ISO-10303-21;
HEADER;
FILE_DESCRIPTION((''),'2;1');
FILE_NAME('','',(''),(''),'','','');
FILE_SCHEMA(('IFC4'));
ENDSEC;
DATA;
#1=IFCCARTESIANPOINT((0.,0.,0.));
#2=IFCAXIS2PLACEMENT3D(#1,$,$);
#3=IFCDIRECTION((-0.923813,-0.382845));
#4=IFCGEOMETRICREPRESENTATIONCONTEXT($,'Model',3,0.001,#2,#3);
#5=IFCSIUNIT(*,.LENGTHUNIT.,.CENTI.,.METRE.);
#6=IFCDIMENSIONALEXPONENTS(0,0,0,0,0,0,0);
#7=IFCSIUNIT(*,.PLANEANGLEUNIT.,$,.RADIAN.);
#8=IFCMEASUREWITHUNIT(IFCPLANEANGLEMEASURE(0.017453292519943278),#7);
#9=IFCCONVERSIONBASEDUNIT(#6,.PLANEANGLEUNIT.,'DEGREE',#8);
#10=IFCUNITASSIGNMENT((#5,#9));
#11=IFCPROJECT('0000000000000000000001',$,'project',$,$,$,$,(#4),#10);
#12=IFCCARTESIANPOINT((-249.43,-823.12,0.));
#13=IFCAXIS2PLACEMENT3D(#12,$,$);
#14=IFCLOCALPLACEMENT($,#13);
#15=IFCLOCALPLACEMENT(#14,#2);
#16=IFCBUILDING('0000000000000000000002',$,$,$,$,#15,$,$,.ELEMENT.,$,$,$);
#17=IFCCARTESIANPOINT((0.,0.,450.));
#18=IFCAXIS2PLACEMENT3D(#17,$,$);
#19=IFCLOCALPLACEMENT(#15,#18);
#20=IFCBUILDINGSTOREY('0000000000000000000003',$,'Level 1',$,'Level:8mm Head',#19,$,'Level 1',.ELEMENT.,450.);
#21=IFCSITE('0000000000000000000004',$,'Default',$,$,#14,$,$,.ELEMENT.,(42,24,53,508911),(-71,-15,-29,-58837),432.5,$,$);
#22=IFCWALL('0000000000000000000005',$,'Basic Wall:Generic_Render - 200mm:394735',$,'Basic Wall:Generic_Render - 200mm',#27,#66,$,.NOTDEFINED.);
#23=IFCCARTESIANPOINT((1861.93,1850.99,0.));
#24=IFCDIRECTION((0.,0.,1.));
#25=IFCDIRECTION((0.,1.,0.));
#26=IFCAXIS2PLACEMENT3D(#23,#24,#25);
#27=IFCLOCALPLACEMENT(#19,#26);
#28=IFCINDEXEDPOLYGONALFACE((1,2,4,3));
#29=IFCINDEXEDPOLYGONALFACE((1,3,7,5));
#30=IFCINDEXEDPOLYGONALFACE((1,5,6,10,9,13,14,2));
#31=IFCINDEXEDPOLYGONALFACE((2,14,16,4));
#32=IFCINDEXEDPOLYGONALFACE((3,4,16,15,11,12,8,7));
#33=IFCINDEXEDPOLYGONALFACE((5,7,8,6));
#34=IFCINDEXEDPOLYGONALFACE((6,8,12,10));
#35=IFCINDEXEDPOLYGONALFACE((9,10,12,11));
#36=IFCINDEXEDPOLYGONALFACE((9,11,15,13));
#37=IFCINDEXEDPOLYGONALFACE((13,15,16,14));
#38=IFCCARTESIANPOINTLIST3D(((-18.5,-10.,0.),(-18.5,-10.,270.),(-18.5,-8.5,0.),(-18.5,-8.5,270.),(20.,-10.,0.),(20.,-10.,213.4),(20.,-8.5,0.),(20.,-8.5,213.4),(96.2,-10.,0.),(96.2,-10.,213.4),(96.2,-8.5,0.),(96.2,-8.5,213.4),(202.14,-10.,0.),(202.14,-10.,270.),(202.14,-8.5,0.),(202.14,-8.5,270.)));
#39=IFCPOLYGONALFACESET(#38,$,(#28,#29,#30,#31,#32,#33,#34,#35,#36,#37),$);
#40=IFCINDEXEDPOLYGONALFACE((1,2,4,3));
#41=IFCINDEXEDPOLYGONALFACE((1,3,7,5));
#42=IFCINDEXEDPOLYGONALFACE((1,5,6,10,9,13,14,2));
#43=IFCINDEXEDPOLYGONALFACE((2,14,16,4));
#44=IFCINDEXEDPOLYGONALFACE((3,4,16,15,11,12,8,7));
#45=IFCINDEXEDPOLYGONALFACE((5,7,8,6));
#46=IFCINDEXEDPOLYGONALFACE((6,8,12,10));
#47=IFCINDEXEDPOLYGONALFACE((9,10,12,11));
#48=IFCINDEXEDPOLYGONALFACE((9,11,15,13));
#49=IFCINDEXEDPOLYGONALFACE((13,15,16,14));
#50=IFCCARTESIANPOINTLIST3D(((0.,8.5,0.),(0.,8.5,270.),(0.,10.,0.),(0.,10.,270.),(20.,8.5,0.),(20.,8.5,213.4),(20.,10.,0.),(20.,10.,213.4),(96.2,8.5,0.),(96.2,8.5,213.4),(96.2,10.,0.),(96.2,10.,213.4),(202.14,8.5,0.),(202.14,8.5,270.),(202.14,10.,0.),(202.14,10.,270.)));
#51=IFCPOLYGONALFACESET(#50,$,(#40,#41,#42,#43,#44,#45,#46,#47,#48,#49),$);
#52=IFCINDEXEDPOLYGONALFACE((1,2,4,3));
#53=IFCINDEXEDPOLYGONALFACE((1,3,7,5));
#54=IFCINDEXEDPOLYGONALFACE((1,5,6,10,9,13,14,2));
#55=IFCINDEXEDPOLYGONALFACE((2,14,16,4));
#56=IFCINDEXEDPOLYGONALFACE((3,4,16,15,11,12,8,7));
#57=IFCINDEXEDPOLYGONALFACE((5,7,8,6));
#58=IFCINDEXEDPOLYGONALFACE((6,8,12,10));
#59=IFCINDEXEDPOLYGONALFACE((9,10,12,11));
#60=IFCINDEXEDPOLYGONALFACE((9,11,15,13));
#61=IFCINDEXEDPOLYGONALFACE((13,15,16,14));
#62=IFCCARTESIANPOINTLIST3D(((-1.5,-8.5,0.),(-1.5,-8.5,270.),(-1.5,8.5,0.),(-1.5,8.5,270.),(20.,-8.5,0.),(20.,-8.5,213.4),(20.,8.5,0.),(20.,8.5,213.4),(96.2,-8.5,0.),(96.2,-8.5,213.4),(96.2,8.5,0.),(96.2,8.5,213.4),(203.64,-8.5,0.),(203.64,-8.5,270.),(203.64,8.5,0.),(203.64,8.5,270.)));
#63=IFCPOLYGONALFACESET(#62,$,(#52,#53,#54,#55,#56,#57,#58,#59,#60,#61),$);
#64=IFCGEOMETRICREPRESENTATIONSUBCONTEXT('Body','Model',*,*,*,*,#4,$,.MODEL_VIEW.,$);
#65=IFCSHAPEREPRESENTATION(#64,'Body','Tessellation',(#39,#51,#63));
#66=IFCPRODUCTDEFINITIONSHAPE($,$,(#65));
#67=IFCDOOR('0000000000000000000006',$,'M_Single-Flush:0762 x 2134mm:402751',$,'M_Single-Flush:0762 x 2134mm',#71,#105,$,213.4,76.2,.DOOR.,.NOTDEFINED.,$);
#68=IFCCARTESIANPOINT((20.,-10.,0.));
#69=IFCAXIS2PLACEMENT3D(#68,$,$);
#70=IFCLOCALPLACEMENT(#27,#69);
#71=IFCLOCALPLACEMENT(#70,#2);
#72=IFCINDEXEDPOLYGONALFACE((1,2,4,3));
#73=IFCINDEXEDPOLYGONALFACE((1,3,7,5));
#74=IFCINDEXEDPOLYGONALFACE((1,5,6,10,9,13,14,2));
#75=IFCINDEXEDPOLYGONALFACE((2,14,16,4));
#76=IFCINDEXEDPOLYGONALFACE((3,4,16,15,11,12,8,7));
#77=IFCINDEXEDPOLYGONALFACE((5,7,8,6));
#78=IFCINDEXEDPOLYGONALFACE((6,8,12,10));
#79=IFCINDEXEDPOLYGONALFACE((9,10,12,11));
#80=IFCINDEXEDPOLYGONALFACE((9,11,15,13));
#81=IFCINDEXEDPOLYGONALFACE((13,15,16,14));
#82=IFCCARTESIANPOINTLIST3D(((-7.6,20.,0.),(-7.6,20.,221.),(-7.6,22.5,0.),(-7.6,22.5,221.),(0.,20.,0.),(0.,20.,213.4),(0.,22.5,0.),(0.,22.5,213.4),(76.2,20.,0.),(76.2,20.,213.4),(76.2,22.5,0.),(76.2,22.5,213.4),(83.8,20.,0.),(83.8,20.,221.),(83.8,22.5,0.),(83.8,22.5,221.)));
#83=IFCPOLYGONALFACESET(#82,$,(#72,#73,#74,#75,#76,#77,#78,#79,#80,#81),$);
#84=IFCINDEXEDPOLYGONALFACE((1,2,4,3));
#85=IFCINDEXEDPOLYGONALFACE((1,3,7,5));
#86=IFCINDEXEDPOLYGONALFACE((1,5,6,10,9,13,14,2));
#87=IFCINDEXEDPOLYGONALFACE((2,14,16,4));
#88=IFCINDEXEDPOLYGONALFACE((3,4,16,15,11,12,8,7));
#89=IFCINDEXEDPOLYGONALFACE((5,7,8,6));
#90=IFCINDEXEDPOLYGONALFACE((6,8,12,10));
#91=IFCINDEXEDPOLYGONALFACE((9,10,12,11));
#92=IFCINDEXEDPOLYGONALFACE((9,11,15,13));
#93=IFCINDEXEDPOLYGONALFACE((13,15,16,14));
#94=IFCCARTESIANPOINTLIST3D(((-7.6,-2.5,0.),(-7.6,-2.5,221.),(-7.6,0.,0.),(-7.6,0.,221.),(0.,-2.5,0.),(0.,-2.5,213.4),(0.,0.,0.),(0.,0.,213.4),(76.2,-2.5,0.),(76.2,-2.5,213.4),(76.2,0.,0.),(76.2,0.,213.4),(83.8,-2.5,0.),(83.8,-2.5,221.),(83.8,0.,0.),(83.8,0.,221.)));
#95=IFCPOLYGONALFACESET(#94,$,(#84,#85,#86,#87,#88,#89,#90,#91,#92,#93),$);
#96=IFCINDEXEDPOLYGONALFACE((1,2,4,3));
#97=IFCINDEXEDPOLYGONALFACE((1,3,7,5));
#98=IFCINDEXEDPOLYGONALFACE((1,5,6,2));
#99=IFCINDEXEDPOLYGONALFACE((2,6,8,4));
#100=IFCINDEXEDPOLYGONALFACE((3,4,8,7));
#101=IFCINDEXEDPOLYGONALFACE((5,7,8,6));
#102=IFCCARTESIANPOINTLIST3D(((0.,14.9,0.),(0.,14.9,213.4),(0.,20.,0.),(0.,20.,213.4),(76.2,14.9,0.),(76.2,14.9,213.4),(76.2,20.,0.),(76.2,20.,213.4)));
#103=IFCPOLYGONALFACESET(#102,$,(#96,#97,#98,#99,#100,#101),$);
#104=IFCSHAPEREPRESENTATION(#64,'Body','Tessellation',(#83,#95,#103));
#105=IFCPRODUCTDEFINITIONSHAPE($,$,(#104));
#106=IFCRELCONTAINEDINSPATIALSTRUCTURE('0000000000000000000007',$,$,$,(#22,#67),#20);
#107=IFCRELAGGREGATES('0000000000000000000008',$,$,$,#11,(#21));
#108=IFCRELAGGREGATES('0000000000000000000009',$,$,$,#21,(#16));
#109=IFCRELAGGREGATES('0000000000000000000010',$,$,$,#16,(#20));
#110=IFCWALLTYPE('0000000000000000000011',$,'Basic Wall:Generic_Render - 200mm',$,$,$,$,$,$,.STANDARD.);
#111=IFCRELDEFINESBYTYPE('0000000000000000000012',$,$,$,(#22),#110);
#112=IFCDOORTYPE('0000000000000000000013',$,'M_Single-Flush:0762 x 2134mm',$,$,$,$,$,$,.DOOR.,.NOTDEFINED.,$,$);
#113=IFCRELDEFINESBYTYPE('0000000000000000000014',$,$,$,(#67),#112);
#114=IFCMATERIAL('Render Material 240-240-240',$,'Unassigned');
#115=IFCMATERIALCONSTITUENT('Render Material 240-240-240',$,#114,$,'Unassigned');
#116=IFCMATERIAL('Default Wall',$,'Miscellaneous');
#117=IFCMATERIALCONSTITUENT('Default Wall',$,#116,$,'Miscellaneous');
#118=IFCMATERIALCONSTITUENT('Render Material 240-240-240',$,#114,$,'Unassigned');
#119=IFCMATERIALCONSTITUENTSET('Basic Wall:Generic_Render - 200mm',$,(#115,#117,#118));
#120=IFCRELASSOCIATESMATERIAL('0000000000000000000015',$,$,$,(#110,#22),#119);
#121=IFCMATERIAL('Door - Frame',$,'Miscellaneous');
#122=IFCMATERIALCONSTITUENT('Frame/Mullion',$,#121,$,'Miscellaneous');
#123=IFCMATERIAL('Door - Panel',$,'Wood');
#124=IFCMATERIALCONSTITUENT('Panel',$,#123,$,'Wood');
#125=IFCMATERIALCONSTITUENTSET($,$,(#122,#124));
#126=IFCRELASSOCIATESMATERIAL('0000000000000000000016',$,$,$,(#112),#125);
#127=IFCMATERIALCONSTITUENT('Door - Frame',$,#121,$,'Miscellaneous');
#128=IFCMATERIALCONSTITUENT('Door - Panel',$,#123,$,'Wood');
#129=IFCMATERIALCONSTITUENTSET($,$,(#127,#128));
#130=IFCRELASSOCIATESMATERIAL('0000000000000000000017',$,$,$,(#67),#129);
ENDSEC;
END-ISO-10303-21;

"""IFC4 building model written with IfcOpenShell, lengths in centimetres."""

from ifc_helpers import new_model, entity, si_unit, converted_unit, direction, frame, origin, place, context, subcontext, project, spatial, indexed_curve, outline, extrude, source, transform, mapped, material, constituent, constituent_set, type_object, type_shapes, element, fill, save


model = new_model("IFC4")

# Units and contexts
model_context = context("Model", 3, precision=0.001, world=origin(), true_north=direction((-0.923813, -0.382845)))
body_context = subcontext(model_context, "Body", "Model", "MODEL_VIEW")
ifc_project = project(units=[si_unit("LENGTHUNIT", "METRE", prefix="CENTI"), converted_unit("PLANEANGLEUNIT", "DEGREE", entity("IfcPlaneAngleMeasure", 0.017453292519943278), si_unit("PLANEANGLEUNIT", "RADIAN"), dimensions=[0, 0, 0, 0, 0, 0, 0])], contexts=[model_context])

# Site, building, storey
site_placement = place(None, frame((-249.43, -823.12, 0.0)))
site = spatial("IfcSite", under=ifc_project, at=site_placement, Name="Default", CompositionType="ELEMENT", RefLatitude=(42, 24, 53, 508911), RefLongitude=(-71, -15, -29, -58837), RefElevation=432.5)
building_placement = place(site_placement, origin())
building = spatial("IfcBuilding", under=site, at=building_placement, CompositionType="ELEMENT")
storey_placement = place(building_placement, frame((0.0, 0.0, 450.0)))
storey = spatial("IfcBuildingStorey", under=building, at=storey_placement, Name="Level 1", ObjectType="Level:8mm Head", LongName="Level 1", CompositionType="ELEMENT", Elevation=450.0)

# Shared definitions
ifc_material_1 = material(Name="Render Material 240-240-240", Category="Unassigned")
ifc_material_2 = material(Name="Default Wall", Category="Miscellaneous")
ifc_constituent_1 = constituent(ifc_material_1, Name="Render Material 240-240-240", Category="Unassigned")
ifc_constituent_2 = constituent(ifc_material_2, Name="Default Wall", Category="Miscellaneous")
ifc_constituent_3 = constituent(ifc_material_1, Name="Render Material 240-240-240", Category="Unassigned")
ifc_constituent_set_1 = constituent_set(constituents=[ifc_constituent_1, ifc_constituent_2, ifc_constituent_3], Name="Basic Wall:Generic_Render - 200mm")
wall_type_1 = type_object("IfcWallType", Name="Basic Wall:Generic_Render - 200mm", PredefinedType="STANDARD", material=ifc_constituent_set_1)

# Shared definitions
ifc_material_3 = material(Name="Door - Frame", Category="Miscellaneous")
ifc_material_4 = material(Name="Door - Panel", Category="Wood")

# Wall, opening, door
wall_1_placement = place(storey_placement, frame((1861.93, 1850.99, 0.0), z_axis=(0.0, 0.0, 1.0), x_axis=(0.0, 1.0, 0.0)))
wall_1 = element("IfcWall", 1, at=wall_1_placement, inside=storey, type_object=wall_type_1, material=ifc_constituent_set_1, Name="Basic Wall:Generic_Render - 200mm:394735", ObjectType="Basic Wall:Generic_Render - 200mm", PredefinedType="NOTDEFINED", context=body_context, shape_type="SweptSolid", body=[
    extrude(outline(indexed_curve([(-120.85, -127.18), (149.15, -127.18), (149.15, 93.46), (-120.85, 93.46), (-120.85, 54.96), (92.55, 54.96), (92.55, -21.24), (-120.85, -21.24), (-120.85, -127.18)], self_intersect=False)), frame((74.96, -8.5, 120.85), z_axis=(0.0, -1.0, 0.0), x_axis=(0.0, 0.0, 1.0)), (0.0, 0.0, 1.0), 1.5),
    extrude(outline(indexed_curve([(-59.58, -92.55), (-59.58, 120.85), (-79.58, 120.85), (-79.58, -149.15), (122.55, -149.15), (122.55, 120.85), (16.62, 120.85), (16.62, -92.55), (-59.58, -92.55)], self_intersect=False)), frame((79.58, 10.0, 120.85), z_axis=(0.0, 1.0, 0.0), x_axis=(1.0, 0.0, 0.0)), (0.0, 0.0, -1.0), 1.5),
    extrude(outline(indexed_curve([(-120.85, -124.05), (149.15, -124.05), (149.15, 81.08), (-120.85, 81.08), (-120.85, 59.58), (92.55, 59.58), (92.55, -16.62), (-120.85, -16.62), (-120.85, -124.05)], self_intersect=False)), frame((79.58, 8.5, 120.85), z_axis=(0.0, -1.0, 0.0), x_axis=(0.0, 0.0, 1.0)), (0.0, 0.0, 1.0), 17.0),
])
opening_1_placement = place(wall_1_placement, frame((20.0, -10.0, 0.0)))
opening_1 = element("IfcOpeningElement", 2, at=opening_1_placement, cuts=wall_1, PredefinedType="OPENING", context=body_context, shape_type="SweptSolid", body=[
    extrude(outline(indexed_curve([(0.0, 76.2), (0.0, 0.0), (213.4, 0.0), (213.4, 76.2), (0.0, 76.2)], self_intersect=False)), frame((0.0, 0.0, 0.0), z_axis=(0.0, 1.0, 0.0), x_axis=(0.0, 0.0, 1.0)), (0.0, 0.0, 1.0), 20.0),
])
ifc_constituent_4 = constituent(ifc_material_3, Name="Door - Frame", Category="Miscellaneous")
ifc_constituent_5 = constituent(ifc_material_4, Name="Door - Panel", Category="Wood")
ifc_constituent_set_2 = constituent_set(constituents=[ifc_constituent_4, ifc_constituent_5])
ifc_constituent_6 = constituent(ifc_material_3, Name="Frame/Mullion", Category="Miscellaneous")
ifc_constituent_7 = constituent(ifc_material_4, Name="Panel", Category="Wood")
ifc_constituent_set_3 = constituent_set(constituents=[ifc_constituent_6, ifc_constituent_7])
door_type_1 = type_object("IfcDoorType", Name="M_Single-Flush:0762 x 2134mm", OperationType="NOTDEFINED", PredefinedType="DOOR", material=ifc_constituent_set_3)
shared_shape_1 = source(origin(), body_context, "Body", "SweptSolid", [
    extrude(outline(indexed_curve([(-45.7, -112.4), (45.7, -112.4), (45.7, 108.6), (38.1, 108.6), (38.1, -104.8), (-38.1, -104.8), (-38.1, 108.6), (-45.7, 108.6), (-45.7, -112.4)], self_intersect=False)), frame((38.1, 22.5, 108.6), z_axis=(0.0, -1.0, 0.0), x_axis=(-1.0, 0.0, 0.0)), (0.0, 0.0, 1.0), 2.5),
    extrude(outline(indexed_curve([(-112.4, -45.7), (108.6, -45.7), (108.6, -38.1), (-104.8, -38.1), (-104.8, 38.1), (108.6, 38.1), (108.6, 45.7), (-112.4, 45.7), (-112.4, -45.7)], self_intersect=False)), frame((38.1, 0.0, 108.6), z_axis=(0.0, -1.0, 0.0), x_axis=(0.0, 0.0, -1.0)), (0.0, 0.0, 1.0), 2.5),
    extrude(outline(indexed_curve([(-38.1, -2.55), (38.1, -2.55), (38.1, 2.55), (-38.1, 2.55), (-38.1, -2.55)], self_intersect=False)), frame((38.1, 17.45, 0.0)), (0.0, 0.0, 1.0), 213.4),
])
type_shapes(door_type_1, [shared_shape_1])
door_1_placement = place(opening_1_placement, origin())
door_1 = element("IfcDoor", 3, at=door_1_placement, inside=storey, type_object=door_type_1, material=ifc_constituent_set_2, Name="M_Single-Flush:0762 x 2134mm:402751", ObjectType="M_Single-Flush:0762 x 2134mm", OperationType="NOTDEFINED", OverallHeight=213.4, OverallWidth=76.2, PredefinedType="DOOR", context=body_context, shape_type="MappedRepresentation", body=[
    mapped(shared_shape_1, transform((0.0, 0.0, 0.0), scale=1.0)),
])
fill(opening_1, door_1)

save(model, "model.ifc")
